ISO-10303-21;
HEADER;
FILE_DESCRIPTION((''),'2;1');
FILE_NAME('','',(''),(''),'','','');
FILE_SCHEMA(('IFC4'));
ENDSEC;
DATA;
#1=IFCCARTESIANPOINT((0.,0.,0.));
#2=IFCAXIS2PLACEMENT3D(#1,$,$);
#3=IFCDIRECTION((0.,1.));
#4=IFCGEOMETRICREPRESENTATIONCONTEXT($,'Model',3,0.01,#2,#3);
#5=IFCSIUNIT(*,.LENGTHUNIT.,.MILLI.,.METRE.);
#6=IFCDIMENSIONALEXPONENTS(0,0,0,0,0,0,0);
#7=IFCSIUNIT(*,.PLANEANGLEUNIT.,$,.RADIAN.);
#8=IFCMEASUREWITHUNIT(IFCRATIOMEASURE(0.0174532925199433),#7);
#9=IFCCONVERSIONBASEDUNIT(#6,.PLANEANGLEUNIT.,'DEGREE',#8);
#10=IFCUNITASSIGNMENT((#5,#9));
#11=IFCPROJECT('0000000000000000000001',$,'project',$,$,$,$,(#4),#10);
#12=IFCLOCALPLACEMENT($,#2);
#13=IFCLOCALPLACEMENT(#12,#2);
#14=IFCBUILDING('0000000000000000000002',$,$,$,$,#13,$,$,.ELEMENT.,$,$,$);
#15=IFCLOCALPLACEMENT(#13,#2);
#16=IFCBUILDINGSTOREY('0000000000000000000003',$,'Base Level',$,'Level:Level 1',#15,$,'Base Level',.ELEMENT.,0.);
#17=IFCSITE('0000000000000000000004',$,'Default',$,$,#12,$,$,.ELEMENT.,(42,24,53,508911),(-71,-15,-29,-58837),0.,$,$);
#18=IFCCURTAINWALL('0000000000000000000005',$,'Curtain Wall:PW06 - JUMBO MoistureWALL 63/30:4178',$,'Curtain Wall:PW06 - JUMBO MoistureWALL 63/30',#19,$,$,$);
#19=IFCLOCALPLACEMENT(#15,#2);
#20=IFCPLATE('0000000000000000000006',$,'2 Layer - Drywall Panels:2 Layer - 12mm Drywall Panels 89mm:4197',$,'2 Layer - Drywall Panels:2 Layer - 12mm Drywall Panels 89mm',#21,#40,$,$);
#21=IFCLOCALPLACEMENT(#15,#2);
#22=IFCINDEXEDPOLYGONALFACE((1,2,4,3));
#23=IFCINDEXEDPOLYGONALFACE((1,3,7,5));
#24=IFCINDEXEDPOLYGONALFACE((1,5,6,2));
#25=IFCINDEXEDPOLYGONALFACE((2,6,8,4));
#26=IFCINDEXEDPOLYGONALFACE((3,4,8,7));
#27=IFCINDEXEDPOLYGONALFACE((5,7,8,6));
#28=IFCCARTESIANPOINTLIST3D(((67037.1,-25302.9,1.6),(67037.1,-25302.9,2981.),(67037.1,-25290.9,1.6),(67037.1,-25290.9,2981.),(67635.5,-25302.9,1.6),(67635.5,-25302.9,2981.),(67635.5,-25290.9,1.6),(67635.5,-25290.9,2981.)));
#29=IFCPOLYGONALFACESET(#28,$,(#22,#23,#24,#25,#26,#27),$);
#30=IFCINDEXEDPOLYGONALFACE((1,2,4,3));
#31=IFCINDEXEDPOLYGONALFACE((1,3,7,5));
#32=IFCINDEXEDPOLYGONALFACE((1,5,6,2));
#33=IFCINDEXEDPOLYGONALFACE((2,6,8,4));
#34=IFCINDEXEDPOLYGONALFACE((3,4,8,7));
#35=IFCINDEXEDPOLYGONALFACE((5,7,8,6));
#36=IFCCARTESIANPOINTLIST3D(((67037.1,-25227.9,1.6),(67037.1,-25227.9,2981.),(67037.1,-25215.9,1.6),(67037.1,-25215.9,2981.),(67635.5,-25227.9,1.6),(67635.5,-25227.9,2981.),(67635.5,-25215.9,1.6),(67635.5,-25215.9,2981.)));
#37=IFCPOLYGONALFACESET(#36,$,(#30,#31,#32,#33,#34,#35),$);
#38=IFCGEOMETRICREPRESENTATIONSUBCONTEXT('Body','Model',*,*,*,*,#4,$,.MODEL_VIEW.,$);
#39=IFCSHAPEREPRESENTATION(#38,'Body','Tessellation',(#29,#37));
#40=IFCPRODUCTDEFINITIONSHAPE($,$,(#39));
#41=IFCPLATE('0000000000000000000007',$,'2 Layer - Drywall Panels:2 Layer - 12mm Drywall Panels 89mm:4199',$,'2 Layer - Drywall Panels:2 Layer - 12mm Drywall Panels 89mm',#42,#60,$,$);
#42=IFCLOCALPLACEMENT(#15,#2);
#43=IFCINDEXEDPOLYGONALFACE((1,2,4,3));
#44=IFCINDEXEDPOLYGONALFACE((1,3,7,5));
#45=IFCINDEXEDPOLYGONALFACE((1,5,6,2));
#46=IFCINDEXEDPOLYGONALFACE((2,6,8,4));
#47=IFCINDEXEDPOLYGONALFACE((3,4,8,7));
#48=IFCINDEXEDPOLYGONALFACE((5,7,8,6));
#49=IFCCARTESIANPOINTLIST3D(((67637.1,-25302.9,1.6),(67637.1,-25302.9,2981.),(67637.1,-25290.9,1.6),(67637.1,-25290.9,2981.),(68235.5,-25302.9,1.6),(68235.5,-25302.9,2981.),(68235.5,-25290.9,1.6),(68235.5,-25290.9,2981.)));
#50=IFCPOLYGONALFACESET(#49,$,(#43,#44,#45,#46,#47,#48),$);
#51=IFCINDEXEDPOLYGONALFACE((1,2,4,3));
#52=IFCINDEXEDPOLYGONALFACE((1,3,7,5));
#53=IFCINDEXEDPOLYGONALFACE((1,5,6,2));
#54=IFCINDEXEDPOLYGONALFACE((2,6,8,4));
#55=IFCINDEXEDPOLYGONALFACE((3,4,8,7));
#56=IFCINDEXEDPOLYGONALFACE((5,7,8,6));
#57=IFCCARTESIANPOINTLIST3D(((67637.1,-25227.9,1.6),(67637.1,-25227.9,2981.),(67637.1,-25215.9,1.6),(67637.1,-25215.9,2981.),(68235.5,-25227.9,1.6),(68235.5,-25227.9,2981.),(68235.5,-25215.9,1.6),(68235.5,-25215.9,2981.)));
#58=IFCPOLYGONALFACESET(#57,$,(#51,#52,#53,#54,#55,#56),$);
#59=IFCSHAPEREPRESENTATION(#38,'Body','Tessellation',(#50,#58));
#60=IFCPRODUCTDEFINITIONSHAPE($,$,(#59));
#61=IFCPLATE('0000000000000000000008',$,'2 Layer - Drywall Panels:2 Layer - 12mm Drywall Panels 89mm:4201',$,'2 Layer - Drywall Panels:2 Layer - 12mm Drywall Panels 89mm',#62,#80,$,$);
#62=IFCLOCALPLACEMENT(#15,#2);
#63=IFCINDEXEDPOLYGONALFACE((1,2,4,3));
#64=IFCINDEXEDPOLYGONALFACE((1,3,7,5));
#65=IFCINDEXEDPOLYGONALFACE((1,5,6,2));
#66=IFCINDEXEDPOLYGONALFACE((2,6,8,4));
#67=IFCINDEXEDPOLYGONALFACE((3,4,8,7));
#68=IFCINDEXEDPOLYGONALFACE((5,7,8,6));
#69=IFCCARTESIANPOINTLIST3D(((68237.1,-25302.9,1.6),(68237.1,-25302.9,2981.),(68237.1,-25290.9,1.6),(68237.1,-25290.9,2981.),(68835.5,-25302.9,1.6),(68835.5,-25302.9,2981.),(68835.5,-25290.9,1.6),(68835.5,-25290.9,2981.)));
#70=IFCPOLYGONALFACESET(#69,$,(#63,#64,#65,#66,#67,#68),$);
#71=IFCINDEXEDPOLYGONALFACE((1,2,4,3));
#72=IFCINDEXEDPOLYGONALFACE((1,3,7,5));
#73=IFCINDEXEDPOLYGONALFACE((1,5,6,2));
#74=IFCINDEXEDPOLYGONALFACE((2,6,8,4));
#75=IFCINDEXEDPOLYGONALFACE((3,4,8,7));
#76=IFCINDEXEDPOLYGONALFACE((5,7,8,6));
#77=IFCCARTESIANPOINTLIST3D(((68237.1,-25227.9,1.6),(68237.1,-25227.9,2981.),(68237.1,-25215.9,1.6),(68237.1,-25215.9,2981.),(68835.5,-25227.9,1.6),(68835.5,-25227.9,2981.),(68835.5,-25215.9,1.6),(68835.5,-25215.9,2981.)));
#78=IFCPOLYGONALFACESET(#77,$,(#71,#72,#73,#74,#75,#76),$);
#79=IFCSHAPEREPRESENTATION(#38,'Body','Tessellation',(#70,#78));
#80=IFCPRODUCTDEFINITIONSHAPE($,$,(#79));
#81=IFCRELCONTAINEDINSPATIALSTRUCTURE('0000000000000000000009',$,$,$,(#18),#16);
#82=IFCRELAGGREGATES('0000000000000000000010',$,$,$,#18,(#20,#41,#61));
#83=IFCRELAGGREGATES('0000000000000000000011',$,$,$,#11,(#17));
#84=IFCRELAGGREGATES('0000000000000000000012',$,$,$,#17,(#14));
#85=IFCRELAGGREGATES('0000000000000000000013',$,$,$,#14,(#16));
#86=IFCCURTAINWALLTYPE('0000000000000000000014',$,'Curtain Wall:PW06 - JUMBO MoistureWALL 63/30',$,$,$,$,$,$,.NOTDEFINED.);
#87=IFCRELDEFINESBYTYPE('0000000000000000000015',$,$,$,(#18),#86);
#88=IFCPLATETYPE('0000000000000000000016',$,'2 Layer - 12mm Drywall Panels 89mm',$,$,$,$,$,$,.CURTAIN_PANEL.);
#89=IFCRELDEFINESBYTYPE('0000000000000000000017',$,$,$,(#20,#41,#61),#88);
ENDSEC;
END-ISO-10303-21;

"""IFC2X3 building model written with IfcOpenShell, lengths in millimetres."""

from ifc_helpers import new_model, entity, si_unit, converted_unit, direction, frame, frame_2d, origin, place, context, subcontext, project, spatial, rectangle, extrude, source, transform, mapped, type_object, type_shapes, element, aggregate, save


model = new_model("IFC2X3")

# Units and contexts
model_context = context("Model", 3, precision=0.01, world=origin(), true_north=direction((0.0, 1.0)))
body_context = subcontext(model_context, "Body", "Model", "MODEL_VIEW")
ifc_project = project(units=[si_unit("LENGTHUNIT", "METRE", prefix="MILLI"), converted_unit("PLANEANGLEUNIT", "DEGREE", entity("IfcRatioMeasure", 0.0174532925199433), si_unit("PLANEANGLEUNIT", "RADIAN"), dimensions=[0, 0, 0, 0, 0, 0, 0])], contexts=[model_context])

# Site, building, storey
site_placement = place(None, origin())
site = spatial("IfcSite", under=ifc_project, at=site_placement, Name="Default", CompositionType="ELEMENT", RefLatitude=(42, 24, 53, 508911), RefLongitude=(-71, -15, -29, -58837), RefElevation=0.0)
building_placement = place(site_placement, origin())
building = spatial("IfcBuilding", under=site, at=building_placement, CompositionType="ELEMENT")
storey_placement = place(building_placement, origin())
storey = spatial("IfcBuildingStorey", under=building, at=storey_placement, Name="Base Level", ObjectType="Level:Level 1", LongName="Base Level", CompositionType="ELEMENT", Elevation=0.0)

# Curtain wall, plates
curtain_wall_type = type_object("IfcCurtainWallType", Name="Curtain Wall:PW06 - JUMBO MoistureWALL 63/30", PredefinedType="NOTDEFINED")
curtain_wall_placement = place(building_placement, origin())
curtain_wall = element("IfcCurtainWall", 1, at=curtain_wall_placement, inside=storey, type_object=curtain_wall_type, Name="Curtain Wall:PW06 - JUMBO MoistureWALL 63/30:4178", ObjectType="Curtain Wall:PW06 - JUMBO MoistureWALL 63/30")
plate_type = type_object("IfcPlateType", Name="2 Layer - 12mm Drywall Panels 89mm", PredefinedType="CURTAIN_PANEL")
shared_shape_1 = source(origin(), body_context, "Body", "SweptSolid", [
    extrude(rectangle(XDim=598.4, YDim=12.0, at=frame_2d((0.0, 0.0), x_axis=(1.0, 0.0))), frame((0.0, -37.5, 0.0), z_axis=(0.0, 0.0, 1.0), x_axis=(-1.0, 0.0, 0.0)), (0.0, 0.0, 1.0), 2979.4),
    extrude(rectangle(XDim=12.0, YDim=598.4, at=frame_2d((0.0, 0.0), x_axis=(1.0, 0.0))), frame((0.0, 37.5, 0.0), z_axis=(0.0, 0.0, 1.0), x_axis=(0.0, 1.0, 0.0)), (0.0, 0.0, 1.0), 2979.4),
])
type_shapes(plate_type, [shared_shape_1])
plate_1_placement = place(curtain_wall_placement, frame((67336.3, -25259.4, 1.6)))
plate_1 = element("IfcPlate", 2, at=plate_1_placement, type_object=plate_type, Name="2 Layer - Drywall Panels:2 Layer - 12mm Drywall Panels 89mm:4197", ObjectType="2 Layer - Drywall Panels:2 Layer - 12mm Drywall Panels 89mm", context=body_context, shape_type="MappedRepresentation", body=[
    mapped(shared_shape_1, transform((0.0, 0.0, 0.0), scale=1.0)),
])
plate_2_placement = place(curtain_wall_placement, frame((67936.3, -25259.4, 1.6)))
plate_2 = element("IfcPlate", 3, at=plate_2_placement, type_object=plate_type, Name="2 Layer - Drywall Panels:2 Layer - 12mm Drywall Panels 89mm:4199", ObjectType="2 Layer - Drywall Panels:2 Layer - 12mm Drywall Panels 89mm", context=body_context, shape_type="MappedRepresentation", body=[
    mapped(shared_shape_1, transform((0.0, 0.0, 0.0), scale=1.0)),
])
plate_3_placement = place(curtain_wall_placement, frame((68536.3, -25259.4, 1.6)))
plate_3 = element("IfcPlate", 4, at=plate_3_placement, type_object=plate_type, Name="2 Layer - Drywall Panels:2 Layer - 12mm Drywall Panels 89mm:4201", ObjectType="2 Layer - Drywall Panels:2 Layer - 12mm Drywall Panels 89mm", context=body_context, shape_type="MappedRepresentation", body=[
    mapped(shared_shape_1, transform((0.0, 0.0, 0.0), scale=1.0)),
])
aggregate(curtain_wall, [plate_1, plate_2, plate_3])

save(model, "model.ifc")
